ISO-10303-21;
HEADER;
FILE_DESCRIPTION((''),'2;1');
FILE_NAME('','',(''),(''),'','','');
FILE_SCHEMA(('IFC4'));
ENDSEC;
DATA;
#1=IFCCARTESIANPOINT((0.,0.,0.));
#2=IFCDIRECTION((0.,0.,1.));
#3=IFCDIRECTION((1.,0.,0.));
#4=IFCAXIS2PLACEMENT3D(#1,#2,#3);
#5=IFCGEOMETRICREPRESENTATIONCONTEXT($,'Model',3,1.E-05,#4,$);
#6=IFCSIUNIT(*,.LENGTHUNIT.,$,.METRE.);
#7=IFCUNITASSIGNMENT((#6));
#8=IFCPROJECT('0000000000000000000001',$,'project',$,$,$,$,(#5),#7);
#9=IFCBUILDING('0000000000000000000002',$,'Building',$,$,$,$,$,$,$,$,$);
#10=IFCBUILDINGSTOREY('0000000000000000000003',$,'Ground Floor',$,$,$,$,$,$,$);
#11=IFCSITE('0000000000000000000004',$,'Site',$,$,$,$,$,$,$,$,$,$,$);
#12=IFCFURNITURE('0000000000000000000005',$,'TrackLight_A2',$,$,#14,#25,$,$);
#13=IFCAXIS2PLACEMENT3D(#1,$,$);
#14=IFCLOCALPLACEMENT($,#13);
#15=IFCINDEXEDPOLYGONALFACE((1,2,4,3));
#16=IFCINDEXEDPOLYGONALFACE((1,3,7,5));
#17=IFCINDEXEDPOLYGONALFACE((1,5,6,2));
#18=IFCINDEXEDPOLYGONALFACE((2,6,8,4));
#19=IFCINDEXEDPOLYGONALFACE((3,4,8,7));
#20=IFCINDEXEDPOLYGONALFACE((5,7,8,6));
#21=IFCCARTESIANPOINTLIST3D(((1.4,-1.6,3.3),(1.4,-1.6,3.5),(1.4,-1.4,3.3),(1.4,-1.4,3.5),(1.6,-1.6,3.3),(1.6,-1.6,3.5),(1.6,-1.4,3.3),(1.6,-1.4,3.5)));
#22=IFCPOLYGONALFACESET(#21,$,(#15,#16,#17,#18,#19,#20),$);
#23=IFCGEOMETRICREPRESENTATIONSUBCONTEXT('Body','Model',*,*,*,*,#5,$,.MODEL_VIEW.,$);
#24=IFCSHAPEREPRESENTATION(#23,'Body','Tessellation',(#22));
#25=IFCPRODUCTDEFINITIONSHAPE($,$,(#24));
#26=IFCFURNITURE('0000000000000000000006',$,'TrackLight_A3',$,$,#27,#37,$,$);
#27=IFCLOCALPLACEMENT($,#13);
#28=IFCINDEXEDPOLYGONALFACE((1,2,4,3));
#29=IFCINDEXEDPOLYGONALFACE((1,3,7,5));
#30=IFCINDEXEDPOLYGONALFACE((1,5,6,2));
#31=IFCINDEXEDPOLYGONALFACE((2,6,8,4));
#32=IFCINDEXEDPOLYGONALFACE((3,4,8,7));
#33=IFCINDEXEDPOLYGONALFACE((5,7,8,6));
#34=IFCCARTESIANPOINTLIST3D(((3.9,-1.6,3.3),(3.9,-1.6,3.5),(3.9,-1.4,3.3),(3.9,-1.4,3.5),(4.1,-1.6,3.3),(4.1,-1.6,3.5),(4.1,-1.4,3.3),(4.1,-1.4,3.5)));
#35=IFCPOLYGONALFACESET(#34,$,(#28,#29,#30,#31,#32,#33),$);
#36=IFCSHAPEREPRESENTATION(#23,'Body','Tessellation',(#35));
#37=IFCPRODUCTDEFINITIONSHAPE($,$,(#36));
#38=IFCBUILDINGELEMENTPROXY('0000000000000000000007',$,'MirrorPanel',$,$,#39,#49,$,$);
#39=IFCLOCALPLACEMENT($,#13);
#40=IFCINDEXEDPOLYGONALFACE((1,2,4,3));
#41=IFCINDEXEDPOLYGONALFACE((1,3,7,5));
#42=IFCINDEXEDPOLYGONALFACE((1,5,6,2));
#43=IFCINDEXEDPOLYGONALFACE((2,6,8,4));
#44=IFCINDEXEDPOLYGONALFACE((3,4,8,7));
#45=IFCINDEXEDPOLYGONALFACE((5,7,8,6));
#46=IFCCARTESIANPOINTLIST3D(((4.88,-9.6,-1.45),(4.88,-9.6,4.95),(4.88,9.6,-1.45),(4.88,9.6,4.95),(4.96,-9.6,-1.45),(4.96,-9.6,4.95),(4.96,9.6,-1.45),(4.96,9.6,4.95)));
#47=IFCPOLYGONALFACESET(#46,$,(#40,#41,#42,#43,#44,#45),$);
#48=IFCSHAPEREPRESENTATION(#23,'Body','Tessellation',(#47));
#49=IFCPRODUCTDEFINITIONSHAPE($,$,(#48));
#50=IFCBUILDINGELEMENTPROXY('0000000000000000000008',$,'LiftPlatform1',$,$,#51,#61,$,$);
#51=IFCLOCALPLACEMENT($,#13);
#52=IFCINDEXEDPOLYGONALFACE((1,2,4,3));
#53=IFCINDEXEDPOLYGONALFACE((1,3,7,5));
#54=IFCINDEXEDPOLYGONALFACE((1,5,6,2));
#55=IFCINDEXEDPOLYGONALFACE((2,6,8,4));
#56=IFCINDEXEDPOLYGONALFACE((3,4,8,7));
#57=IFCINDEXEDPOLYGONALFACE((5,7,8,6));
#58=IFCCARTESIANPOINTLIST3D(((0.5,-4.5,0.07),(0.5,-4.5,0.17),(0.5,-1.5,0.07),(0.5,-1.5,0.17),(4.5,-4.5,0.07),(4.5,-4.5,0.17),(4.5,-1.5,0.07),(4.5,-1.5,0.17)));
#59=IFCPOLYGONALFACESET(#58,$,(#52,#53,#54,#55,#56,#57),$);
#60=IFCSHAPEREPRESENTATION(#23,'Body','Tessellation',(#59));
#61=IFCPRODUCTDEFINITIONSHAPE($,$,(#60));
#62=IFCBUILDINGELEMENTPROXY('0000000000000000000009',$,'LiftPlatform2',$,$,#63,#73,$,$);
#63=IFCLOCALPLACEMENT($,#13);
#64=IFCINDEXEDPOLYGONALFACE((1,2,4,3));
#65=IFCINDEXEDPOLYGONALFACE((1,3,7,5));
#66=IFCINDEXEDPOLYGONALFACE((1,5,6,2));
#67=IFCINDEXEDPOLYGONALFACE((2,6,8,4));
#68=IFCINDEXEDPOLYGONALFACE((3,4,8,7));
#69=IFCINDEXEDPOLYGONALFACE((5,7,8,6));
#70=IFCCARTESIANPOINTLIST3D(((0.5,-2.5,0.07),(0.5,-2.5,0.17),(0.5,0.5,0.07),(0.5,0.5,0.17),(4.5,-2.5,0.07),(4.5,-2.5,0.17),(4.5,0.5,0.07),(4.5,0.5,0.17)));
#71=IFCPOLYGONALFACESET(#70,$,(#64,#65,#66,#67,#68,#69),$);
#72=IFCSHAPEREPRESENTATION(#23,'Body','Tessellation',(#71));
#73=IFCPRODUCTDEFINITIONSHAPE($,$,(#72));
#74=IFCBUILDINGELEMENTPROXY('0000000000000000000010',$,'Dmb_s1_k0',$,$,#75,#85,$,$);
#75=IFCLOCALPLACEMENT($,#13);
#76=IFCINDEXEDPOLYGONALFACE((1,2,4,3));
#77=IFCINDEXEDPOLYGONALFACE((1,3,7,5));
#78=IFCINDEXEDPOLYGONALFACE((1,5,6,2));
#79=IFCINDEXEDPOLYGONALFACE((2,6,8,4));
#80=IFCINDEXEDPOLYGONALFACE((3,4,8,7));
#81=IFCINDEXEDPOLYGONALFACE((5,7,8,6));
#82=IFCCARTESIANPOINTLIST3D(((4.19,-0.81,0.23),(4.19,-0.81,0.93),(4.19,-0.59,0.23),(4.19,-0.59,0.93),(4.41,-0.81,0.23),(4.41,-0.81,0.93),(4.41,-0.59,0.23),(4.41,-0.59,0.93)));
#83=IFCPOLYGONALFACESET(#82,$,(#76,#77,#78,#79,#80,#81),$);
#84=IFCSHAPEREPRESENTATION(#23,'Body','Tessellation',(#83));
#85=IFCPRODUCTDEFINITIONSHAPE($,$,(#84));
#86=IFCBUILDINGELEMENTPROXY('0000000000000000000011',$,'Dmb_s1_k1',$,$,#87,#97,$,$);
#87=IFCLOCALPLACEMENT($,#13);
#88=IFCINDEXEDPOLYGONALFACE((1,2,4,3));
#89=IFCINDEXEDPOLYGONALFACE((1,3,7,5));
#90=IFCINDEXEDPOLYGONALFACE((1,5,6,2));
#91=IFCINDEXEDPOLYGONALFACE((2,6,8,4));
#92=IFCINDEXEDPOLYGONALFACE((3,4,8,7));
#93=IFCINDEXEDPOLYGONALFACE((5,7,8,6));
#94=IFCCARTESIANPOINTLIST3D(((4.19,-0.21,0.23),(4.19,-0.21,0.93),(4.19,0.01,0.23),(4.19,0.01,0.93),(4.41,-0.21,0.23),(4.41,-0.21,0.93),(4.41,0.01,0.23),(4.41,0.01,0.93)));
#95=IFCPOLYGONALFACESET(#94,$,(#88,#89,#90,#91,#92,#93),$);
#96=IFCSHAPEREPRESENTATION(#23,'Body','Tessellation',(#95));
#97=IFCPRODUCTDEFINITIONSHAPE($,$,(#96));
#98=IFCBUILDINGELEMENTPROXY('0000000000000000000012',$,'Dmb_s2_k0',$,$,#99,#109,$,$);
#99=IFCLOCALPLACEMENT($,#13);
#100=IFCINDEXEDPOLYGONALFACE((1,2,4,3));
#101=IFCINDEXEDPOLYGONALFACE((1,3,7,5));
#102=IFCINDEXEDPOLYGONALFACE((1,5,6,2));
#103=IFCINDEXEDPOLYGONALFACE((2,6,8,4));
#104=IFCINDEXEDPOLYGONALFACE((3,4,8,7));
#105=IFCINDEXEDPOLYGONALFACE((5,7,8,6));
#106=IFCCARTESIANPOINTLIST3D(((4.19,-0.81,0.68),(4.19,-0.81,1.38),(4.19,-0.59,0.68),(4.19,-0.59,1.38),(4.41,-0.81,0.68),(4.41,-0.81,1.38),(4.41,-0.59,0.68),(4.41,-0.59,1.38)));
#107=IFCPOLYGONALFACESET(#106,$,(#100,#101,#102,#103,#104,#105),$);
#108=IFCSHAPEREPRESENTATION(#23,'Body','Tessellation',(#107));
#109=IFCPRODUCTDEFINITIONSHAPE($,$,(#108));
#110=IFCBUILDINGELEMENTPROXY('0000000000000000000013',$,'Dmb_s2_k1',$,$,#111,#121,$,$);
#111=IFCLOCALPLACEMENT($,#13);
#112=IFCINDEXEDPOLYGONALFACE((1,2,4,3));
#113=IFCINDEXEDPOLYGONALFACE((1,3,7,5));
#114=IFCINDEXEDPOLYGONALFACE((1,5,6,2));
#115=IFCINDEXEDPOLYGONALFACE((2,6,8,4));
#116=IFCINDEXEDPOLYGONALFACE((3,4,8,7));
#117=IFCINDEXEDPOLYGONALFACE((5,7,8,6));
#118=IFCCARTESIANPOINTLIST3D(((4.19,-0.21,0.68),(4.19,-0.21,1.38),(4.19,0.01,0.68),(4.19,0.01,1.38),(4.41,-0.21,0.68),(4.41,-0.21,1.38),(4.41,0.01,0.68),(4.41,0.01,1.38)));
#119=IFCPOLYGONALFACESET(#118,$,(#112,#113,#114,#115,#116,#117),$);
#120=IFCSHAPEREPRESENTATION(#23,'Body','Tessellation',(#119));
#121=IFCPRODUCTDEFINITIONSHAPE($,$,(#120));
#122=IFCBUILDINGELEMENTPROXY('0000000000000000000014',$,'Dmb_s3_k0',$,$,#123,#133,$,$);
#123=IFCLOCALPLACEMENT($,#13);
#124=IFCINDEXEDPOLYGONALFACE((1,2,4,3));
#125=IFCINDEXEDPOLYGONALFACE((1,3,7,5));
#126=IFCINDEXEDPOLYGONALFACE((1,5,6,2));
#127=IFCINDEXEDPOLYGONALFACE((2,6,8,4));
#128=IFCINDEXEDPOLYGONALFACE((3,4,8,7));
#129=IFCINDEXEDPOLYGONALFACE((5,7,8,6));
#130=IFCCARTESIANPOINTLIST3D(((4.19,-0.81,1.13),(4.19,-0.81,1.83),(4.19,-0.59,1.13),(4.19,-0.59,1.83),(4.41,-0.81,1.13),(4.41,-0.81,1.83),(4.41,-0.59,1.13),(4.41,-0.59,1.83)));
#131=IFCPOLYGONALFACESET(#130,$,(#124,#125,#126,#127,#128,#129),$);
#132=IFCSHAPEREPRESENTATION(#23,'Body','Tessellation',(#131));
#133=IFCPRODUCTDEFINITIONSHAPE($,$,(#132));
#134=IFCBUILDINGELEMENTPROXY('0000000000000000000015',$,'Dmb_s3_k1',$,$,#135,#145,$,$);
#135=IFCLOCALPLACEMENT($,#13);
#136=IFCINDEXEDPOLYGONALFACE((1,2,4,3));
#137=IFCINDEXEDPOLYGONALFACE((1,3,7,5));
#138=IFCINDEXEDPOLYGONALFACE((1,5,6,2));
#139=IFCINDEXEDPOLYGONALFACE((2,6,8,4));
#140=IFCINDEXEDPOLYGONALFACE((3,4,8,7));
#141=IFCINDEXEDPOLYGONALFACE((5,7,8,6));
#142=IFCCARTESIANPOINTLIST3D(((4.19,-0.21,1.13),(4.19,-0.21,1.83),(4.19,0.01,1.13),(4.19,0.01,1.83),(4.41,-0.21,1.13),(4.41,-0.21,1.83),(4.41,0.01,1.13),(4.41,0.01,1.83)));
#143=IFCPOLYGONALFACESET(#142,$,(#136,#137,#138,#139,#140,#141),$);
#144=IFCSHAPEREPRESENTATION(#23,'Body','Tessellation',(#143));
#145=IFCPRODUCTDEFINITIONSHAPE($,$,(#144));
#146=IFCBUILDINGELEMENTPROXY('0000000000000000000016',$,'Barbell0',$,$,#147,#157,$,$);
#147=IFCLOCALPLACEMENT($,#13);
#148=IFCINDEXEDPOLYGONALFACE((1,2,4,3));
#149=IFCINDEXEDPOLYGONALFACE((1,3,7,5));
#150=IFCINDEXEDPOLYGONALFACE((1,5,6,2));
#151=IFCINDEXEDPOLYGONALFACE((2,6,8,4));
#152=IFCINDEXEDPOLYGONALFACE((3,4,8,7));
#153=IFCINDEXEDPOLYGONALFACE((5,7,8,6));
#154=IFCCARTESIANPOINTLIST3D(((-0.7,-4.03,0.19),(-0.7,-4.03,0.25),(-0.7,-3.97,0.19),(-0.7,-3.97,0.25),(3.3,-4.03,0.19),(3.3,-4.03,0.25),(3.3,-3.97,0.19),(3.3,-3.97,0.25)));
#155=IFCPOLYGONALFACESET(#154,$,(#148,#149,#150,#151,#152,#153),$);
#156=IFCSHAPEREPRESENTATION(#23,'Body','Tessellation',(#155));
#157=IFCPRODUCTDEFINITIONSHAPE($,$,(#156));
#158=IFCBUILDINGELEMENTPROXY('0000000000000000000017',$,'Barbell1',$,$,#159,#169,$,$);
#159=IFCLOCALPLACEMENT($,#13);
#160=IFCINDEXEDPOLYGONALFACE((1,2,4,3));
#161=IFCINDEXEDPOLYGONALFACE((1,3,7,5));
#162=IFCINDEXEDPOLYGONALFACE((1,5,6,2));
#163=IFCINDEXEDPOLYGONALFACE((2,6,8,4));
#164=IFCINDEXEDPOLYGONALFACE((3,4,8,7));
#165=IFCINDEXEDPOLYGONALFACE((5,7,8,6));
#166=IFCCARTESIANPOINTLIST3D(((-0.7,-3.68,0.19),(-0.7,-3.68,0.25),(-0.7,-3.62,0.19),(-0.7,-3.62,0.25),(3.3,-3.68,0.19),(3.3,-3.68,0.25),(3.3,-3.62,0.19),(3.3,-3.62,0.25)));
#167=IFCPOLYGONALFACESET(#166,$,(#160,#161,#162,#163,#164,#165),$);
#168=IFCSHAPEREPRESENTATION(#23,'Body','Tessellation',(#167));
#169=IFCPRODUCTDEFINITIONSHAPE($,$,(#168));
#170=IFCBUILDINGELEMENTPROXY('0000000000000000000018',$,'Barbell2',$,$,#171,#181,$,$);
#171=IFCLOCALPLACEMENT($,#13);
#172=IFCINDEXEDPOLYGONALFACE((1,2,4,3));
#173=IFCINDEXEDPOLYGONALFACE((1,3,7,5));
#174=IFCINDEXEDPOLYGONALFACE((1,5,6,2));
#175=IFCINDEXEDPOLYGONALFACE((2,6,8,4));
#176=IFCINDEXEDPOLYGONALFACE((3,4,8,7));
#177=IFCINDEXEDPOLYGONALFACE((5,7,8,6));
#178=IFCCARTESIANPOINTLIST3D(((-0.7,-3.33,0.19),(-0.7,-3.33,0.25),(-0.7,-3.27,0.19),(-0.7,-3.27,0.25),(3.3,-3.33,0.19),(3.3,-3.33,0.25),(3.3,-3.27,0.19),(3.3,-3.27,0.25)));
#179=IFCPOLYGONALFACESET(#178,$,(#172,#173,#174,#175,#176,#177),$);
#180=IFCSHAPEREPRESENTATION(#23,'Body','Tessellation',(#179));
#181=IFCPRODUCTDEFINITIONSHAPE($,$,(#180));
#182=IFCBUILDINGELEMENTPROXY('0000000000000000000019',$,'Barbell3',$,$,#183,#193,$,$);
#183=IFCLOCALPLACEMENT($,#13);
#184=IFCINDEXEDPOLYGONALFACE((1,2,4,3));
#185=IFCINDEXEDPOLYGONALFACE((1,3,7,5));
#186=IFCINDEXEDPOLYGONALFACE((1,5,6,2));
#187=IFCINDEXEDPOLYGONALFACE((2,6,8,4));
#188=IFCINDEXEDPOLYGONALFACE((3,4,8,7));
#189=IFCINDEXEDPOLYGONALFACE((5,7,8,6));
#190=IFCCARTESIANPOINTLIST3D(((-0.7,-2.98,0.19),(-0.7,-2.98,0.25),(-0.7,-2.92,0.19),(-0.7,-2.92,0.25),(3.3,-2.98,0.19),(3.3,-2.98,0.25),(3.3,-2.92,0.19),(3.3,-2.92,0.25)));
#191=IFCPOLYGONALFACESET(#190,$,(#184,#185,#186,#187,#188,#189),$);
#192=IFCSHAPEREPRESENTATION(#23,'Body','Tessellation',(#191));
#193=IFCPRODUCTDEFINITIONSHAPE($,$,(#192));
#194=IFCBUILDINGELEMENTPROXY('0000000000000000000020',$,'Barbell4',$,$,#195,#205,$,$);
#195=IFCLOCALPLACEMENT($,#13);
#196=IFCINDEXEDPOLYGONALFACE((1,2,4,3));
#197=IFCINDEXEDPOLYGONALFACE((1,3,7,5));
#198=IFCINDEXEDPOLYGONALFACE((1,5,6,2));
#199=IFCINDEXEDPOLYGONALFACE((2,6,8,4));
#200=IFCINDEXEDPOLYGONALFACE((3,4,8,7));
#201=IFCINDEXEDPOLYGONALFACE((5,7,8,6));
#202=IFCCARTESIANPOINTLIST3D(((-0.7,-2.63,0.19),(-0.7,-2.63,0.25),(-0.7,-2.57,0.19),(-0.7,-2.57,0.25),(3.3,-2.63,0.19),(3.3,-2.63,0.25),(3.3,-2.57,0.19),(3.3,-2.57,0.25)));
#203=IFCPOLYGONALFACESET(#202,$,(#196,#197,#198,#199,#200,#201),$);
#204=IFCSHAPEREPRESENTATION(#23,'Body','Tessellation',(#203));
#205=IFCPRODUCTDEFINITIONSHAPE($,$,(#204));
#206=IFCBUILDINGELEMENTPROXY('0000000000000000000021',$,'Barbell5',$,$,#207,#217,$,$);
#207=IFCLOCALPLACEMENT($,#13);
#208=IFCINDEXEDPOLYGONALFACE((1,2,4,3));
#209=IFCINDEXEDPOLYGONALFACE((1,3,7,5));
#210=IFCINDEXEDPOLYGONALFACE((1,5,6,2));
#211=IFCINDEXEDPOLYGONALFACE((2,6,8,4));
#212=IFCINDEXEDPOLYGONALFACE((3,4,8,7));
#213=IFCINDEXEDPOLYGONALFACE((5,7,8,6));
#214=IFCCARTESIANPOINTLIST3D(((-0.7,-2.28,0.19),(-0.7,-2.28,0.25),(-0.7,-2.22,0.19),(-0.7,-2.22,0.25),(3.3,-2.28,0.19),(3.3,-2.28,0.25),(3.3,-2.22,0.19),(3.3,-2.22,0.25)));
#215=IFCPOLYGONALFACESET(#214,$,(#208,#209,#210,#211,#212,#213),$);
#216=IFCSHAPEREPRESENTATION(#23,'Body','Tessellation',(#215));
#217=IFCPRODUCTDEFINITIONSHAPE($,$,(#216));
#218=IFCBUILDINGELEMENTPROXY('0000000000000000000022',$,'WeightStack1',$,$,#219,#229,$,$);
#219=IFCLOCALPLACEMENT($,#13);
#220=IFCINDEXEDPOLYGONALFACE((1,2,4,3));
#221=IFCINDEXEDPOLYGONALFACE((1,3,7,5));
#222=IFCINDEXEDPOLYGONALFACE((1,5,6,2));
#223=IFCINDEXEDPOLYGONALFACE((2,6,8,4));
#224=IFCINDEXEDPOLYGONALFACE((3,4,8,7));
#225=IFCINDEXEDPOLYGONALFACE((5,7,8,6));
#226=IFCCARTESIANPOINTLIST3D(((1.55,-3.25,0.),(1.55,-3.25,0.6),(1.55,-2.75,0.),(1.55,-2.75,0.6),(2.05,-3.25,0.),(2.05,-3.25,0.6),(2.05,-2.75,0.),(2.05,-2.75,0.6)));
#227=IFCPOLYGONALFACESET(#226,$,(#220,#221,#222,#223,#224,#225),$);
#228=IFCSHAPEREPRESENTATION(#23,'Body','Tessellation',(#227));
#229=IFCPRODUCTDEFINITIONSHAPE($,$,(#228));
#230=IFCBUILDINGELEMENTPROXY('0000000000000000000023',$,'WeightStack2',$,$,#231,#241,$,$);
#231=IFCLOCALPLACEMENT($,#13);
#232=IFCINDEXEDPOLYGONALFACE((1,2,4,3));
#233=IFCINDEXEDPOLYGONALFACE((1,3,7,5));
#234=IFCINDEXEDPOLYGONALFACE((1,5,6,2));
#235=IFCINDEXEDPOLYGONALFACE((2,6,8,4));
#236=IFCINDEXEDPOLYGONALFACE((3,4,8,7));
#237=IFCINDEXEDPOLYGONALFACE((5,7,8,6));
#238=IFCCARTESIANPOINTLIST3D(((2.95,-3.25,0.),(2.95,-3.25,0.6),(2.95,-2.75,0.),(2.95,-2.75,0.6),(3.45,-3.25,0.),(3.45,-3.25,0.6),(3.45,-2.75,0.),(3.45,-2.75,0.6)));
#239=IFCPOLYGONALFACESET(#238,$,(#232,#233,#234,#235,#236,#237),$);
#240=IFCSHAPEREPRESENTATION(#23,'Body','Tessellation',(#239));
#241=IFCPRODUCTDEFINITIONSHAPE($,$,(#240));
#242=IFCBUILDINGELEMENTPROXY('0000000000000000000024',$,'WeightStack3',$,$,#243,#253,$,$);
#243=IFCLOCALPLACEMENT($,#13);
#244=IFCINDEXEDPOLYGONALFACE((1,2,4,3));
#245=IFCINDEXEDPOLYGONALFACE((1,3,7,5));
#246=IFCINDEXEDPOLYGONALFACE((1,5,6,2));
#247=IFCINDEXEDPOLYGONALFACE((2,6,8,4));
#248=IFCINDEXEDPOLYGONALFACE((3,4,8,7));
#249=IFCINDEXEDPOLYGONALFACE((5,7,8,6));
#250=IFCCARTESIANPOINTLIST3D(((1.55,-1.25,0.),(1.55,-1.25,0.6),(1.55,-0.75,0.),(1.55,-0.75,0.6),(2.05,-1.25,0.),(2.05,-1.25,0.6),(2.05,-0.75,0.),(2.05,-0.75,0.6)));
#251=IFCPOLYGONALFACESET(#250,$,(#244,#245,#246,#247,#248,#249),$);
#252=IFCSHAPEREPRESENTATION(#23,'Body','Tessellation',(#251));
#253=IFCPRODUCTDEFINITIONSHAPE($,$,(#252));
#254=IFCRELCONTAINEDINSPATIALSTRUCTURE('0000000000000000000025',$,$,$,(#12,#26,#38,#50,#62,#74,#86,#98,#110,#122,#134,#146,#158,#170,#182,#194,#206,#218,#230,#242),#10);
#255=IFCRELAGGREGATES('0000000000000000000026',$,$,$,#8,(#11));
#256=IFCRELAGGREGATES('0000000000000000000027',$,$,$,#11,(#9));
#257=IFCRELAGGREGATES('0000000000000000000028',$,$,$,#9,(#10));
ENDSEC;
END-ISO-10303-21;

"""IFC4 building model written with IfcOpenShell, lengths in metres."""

from ifc_helpers import new_model, si_unit, frame, origin_with_axes, origin_2d, place, context, subcontext, project, spatial, rectangle, extrude, element, save


model = new_model("IFC4")

# Units and contexts
model_context = context("Model", 3, precision=1e-05, world=origin_with_axes())
body_context = subcontext(model_context, "Body", "Model", "MODEL_VIEW")
ifc_project = project(units=[si_unit("LENGTHUNIT", "METRE")], contexts=[model_context])

# Site, building, storey
site = spatial("IfcSite", under=ifc_project, Name="Site")
building = spatial("IfcBuilding", under=site, Name="Building")
storey = spatial("IfcBuildingStorey", under=building, Name="Ground Floor")

# Furniture
for number, where, z_axis, x_axis, name in (
    (1, (1.5, -1.5, 3.4), (0.0, 0.0, 1.0), (1.0, 0.0, 0.0), "TrackLight_A2"),
    (2, (4.0, -1.5, 3.4), (0.0, 0.0, 1.0), (1.0, 0.0, 0.0), "TrackLight_A3"),
):
    element("IfcFurniture", number, at=place(None, frame(where, z_axis=z_axis, x_axis=x_axis)), inside=storey, Name=name, context=body_context, shape_type="SweptSolid", body=[
        extrude(rectangle(XDim=0.2, YDim=0.2, at=origin_2d()), frame((0.0, 0.0, -0.1)), (0.0, 0.0, 1.0), 0.2),
    ])

# Building element proxies
proxy_1_placement = place(None, frame((4.92, 0.0, 1.75), z_axis=(0.0, 0.0, 1.0), x_axis=(1.0, 0.0, 0.0)))
element("IfcBuildingElementProxy", 3, at=proxy_1_placement, inside=storey, Name="MirrorPanel", context=body_context, shape_type="SweptSolid", body=[
    extrude(rectangle(XDim=0.08, YDim=19.2, at=origin_2d()), frame((0.0, 0.0, -3.2)), (0.0, 0.0, 1.0), 6.4),
])
for number, where, z_axis, x_axis, name in (
    (4, (2.5, -3.0, 0.12), (0.0, 0.0, 1.0), (1.0, 0.0, 0.0), "LiftPlatform1"),
    (5, (2.5, -1.0, 0.12), (0.0, 0.0, 1.0), (1.0, 0.0, 0.0), "LiftPlatform2"),
):
    element("IfcBuildingElementProxy", number, at=place(None, frame(where, z_axis=z_axis, x_axis=x_axis)), inside=storey, Name=name, context=body_context, shape_type="SweptSolid", body=[
        extrude(rectangle(XDim=4.0, YDim=3.0, at=origin_2d()), frame((0.0, 0.0, -0.05)), (0.0, 0.0, 1.0), 0.1),
    ])
for number, where, z_axis, x_axis, name in (
    (6, (4.3, -0.7, 0.58), (0.0, 0.0, 1.0), (1.0, 0.0, 0.0), "Dmb_s1_k0"),
    (7, (4.3, -0.1, 0.58), (0.0, 0.0, 1.0), (1.0, 0.0, 0.0), "Dmb_s1_k1"),
    (8, (4.3, -0.7, 1.03), (0.0, 0.0, 1.0), (1.0, 0.0, 0.0), "Dmb_s2_k0"),
    (9, (4.3, -0.1, 1.03), (0.0, 0.0, 1.0), (1.0, 0.0, 0.0), "Dmb_s2_k1"),
    (10, (4.3, -0.7, 1.48), (0.0, 0.0, 1.0), (1.0, 0.0, 0.0), "Dmb_s3_k0"),
    (11, (4.3, -0.1, 1.48), (0.0, 0.0, 1.0), (1.0, 0.0, 0.0), "Dmb_s3_k1"),
):
    element("IfcBuildingElementProxy", number, at=place(None, frame(where, z_axis=z_axis, x_axis=x_axis)), inside=storey, Name=name, context=body_context, shape_type="SweptSolid", body=[
        extrude(rectangle(XDim=0.22, YDim=0.22, at=origin_2d()), frame((0.0, 0.0, -0.35)), (0.0, 0.0, 1.0), 0.7),
    ])
for number, where, z_axis, x_axis, name in (
    (12, (1.3, -4.0, 0.22), (0.0, 0.0, 1.0), (1.0, 0.0, 0.0), "Barbell0"),
    (13, (1.3, -3.65, 0.22), (0.0, 0.0, 1.0), (1.0, 0.0, 0.0), "Barbell1"),
    (14, (1.3, -3.3, 0.22), (0.0, 0.0, 1.0), (1.0, 0.0, 0.0), "Barbell2"),
    (15, (1.3, -2.95, 0.22), (0.0, 0.0, 1.0), (1.0, 0.0, 0.0), "Barbell3"),
    (16, (1.3, -2.6, 0.22), (0.0, 0.0, 1.0), (1.0, 0.0, 0.0), "Barbell4"),
    (17, (1.3, -2.25, 0.22), (0.0, 0.0, 1.0), (1.0, 0.0, 0.0), "Barbell5"),
):
    element("IfcBuildingElementProxy", number, at=place(None, frame(where, z_axis=z_axis, x_axis=x_axis)), inside=storey, Name=name, context=body_context, shape_type="SweptSolid", body=[
        extrude(rectangle(XDim=4.0, YDim=0.06, at=origin_2d()), frame((0.0, 0.0, -0.03)), (0.0, 0.0, 1.0), 0.06),
    ])
for number, where, z_axis, x_axis, name in (
    (18, (1.8, -3.0, 0.3), (0.0, 0.0, 1.0), (1.0, 0.0, 0.0), "WeightStack1"),
    (19, (3.2, -3.0, 0.3), (0.0, 0.0, 1.0), (1.0, 0.0, 0.0), "WeightStack2"),
    (20, (1.8, -1.0, 0.3), (0.0, 0.0, 1.0), (1.0, 0.0, 0.0), "WeightStack3"),
):
    element("IfcBuildingElementProxy", number, at=place(None, frame(where, z_axis=z_axis, x_axis=x_axis)), inside=storey, Name=name, context=body_context, shape_type="SweptSolid", body=[
        extrude(rectangle(XDim=0.5, YDim=0.5, at=origin_2d()), frame((0.0, 0.0, -0.3)), (0.0, 0.0, 1.0), 0.6),
    ])

save(model, "model.ifc")
